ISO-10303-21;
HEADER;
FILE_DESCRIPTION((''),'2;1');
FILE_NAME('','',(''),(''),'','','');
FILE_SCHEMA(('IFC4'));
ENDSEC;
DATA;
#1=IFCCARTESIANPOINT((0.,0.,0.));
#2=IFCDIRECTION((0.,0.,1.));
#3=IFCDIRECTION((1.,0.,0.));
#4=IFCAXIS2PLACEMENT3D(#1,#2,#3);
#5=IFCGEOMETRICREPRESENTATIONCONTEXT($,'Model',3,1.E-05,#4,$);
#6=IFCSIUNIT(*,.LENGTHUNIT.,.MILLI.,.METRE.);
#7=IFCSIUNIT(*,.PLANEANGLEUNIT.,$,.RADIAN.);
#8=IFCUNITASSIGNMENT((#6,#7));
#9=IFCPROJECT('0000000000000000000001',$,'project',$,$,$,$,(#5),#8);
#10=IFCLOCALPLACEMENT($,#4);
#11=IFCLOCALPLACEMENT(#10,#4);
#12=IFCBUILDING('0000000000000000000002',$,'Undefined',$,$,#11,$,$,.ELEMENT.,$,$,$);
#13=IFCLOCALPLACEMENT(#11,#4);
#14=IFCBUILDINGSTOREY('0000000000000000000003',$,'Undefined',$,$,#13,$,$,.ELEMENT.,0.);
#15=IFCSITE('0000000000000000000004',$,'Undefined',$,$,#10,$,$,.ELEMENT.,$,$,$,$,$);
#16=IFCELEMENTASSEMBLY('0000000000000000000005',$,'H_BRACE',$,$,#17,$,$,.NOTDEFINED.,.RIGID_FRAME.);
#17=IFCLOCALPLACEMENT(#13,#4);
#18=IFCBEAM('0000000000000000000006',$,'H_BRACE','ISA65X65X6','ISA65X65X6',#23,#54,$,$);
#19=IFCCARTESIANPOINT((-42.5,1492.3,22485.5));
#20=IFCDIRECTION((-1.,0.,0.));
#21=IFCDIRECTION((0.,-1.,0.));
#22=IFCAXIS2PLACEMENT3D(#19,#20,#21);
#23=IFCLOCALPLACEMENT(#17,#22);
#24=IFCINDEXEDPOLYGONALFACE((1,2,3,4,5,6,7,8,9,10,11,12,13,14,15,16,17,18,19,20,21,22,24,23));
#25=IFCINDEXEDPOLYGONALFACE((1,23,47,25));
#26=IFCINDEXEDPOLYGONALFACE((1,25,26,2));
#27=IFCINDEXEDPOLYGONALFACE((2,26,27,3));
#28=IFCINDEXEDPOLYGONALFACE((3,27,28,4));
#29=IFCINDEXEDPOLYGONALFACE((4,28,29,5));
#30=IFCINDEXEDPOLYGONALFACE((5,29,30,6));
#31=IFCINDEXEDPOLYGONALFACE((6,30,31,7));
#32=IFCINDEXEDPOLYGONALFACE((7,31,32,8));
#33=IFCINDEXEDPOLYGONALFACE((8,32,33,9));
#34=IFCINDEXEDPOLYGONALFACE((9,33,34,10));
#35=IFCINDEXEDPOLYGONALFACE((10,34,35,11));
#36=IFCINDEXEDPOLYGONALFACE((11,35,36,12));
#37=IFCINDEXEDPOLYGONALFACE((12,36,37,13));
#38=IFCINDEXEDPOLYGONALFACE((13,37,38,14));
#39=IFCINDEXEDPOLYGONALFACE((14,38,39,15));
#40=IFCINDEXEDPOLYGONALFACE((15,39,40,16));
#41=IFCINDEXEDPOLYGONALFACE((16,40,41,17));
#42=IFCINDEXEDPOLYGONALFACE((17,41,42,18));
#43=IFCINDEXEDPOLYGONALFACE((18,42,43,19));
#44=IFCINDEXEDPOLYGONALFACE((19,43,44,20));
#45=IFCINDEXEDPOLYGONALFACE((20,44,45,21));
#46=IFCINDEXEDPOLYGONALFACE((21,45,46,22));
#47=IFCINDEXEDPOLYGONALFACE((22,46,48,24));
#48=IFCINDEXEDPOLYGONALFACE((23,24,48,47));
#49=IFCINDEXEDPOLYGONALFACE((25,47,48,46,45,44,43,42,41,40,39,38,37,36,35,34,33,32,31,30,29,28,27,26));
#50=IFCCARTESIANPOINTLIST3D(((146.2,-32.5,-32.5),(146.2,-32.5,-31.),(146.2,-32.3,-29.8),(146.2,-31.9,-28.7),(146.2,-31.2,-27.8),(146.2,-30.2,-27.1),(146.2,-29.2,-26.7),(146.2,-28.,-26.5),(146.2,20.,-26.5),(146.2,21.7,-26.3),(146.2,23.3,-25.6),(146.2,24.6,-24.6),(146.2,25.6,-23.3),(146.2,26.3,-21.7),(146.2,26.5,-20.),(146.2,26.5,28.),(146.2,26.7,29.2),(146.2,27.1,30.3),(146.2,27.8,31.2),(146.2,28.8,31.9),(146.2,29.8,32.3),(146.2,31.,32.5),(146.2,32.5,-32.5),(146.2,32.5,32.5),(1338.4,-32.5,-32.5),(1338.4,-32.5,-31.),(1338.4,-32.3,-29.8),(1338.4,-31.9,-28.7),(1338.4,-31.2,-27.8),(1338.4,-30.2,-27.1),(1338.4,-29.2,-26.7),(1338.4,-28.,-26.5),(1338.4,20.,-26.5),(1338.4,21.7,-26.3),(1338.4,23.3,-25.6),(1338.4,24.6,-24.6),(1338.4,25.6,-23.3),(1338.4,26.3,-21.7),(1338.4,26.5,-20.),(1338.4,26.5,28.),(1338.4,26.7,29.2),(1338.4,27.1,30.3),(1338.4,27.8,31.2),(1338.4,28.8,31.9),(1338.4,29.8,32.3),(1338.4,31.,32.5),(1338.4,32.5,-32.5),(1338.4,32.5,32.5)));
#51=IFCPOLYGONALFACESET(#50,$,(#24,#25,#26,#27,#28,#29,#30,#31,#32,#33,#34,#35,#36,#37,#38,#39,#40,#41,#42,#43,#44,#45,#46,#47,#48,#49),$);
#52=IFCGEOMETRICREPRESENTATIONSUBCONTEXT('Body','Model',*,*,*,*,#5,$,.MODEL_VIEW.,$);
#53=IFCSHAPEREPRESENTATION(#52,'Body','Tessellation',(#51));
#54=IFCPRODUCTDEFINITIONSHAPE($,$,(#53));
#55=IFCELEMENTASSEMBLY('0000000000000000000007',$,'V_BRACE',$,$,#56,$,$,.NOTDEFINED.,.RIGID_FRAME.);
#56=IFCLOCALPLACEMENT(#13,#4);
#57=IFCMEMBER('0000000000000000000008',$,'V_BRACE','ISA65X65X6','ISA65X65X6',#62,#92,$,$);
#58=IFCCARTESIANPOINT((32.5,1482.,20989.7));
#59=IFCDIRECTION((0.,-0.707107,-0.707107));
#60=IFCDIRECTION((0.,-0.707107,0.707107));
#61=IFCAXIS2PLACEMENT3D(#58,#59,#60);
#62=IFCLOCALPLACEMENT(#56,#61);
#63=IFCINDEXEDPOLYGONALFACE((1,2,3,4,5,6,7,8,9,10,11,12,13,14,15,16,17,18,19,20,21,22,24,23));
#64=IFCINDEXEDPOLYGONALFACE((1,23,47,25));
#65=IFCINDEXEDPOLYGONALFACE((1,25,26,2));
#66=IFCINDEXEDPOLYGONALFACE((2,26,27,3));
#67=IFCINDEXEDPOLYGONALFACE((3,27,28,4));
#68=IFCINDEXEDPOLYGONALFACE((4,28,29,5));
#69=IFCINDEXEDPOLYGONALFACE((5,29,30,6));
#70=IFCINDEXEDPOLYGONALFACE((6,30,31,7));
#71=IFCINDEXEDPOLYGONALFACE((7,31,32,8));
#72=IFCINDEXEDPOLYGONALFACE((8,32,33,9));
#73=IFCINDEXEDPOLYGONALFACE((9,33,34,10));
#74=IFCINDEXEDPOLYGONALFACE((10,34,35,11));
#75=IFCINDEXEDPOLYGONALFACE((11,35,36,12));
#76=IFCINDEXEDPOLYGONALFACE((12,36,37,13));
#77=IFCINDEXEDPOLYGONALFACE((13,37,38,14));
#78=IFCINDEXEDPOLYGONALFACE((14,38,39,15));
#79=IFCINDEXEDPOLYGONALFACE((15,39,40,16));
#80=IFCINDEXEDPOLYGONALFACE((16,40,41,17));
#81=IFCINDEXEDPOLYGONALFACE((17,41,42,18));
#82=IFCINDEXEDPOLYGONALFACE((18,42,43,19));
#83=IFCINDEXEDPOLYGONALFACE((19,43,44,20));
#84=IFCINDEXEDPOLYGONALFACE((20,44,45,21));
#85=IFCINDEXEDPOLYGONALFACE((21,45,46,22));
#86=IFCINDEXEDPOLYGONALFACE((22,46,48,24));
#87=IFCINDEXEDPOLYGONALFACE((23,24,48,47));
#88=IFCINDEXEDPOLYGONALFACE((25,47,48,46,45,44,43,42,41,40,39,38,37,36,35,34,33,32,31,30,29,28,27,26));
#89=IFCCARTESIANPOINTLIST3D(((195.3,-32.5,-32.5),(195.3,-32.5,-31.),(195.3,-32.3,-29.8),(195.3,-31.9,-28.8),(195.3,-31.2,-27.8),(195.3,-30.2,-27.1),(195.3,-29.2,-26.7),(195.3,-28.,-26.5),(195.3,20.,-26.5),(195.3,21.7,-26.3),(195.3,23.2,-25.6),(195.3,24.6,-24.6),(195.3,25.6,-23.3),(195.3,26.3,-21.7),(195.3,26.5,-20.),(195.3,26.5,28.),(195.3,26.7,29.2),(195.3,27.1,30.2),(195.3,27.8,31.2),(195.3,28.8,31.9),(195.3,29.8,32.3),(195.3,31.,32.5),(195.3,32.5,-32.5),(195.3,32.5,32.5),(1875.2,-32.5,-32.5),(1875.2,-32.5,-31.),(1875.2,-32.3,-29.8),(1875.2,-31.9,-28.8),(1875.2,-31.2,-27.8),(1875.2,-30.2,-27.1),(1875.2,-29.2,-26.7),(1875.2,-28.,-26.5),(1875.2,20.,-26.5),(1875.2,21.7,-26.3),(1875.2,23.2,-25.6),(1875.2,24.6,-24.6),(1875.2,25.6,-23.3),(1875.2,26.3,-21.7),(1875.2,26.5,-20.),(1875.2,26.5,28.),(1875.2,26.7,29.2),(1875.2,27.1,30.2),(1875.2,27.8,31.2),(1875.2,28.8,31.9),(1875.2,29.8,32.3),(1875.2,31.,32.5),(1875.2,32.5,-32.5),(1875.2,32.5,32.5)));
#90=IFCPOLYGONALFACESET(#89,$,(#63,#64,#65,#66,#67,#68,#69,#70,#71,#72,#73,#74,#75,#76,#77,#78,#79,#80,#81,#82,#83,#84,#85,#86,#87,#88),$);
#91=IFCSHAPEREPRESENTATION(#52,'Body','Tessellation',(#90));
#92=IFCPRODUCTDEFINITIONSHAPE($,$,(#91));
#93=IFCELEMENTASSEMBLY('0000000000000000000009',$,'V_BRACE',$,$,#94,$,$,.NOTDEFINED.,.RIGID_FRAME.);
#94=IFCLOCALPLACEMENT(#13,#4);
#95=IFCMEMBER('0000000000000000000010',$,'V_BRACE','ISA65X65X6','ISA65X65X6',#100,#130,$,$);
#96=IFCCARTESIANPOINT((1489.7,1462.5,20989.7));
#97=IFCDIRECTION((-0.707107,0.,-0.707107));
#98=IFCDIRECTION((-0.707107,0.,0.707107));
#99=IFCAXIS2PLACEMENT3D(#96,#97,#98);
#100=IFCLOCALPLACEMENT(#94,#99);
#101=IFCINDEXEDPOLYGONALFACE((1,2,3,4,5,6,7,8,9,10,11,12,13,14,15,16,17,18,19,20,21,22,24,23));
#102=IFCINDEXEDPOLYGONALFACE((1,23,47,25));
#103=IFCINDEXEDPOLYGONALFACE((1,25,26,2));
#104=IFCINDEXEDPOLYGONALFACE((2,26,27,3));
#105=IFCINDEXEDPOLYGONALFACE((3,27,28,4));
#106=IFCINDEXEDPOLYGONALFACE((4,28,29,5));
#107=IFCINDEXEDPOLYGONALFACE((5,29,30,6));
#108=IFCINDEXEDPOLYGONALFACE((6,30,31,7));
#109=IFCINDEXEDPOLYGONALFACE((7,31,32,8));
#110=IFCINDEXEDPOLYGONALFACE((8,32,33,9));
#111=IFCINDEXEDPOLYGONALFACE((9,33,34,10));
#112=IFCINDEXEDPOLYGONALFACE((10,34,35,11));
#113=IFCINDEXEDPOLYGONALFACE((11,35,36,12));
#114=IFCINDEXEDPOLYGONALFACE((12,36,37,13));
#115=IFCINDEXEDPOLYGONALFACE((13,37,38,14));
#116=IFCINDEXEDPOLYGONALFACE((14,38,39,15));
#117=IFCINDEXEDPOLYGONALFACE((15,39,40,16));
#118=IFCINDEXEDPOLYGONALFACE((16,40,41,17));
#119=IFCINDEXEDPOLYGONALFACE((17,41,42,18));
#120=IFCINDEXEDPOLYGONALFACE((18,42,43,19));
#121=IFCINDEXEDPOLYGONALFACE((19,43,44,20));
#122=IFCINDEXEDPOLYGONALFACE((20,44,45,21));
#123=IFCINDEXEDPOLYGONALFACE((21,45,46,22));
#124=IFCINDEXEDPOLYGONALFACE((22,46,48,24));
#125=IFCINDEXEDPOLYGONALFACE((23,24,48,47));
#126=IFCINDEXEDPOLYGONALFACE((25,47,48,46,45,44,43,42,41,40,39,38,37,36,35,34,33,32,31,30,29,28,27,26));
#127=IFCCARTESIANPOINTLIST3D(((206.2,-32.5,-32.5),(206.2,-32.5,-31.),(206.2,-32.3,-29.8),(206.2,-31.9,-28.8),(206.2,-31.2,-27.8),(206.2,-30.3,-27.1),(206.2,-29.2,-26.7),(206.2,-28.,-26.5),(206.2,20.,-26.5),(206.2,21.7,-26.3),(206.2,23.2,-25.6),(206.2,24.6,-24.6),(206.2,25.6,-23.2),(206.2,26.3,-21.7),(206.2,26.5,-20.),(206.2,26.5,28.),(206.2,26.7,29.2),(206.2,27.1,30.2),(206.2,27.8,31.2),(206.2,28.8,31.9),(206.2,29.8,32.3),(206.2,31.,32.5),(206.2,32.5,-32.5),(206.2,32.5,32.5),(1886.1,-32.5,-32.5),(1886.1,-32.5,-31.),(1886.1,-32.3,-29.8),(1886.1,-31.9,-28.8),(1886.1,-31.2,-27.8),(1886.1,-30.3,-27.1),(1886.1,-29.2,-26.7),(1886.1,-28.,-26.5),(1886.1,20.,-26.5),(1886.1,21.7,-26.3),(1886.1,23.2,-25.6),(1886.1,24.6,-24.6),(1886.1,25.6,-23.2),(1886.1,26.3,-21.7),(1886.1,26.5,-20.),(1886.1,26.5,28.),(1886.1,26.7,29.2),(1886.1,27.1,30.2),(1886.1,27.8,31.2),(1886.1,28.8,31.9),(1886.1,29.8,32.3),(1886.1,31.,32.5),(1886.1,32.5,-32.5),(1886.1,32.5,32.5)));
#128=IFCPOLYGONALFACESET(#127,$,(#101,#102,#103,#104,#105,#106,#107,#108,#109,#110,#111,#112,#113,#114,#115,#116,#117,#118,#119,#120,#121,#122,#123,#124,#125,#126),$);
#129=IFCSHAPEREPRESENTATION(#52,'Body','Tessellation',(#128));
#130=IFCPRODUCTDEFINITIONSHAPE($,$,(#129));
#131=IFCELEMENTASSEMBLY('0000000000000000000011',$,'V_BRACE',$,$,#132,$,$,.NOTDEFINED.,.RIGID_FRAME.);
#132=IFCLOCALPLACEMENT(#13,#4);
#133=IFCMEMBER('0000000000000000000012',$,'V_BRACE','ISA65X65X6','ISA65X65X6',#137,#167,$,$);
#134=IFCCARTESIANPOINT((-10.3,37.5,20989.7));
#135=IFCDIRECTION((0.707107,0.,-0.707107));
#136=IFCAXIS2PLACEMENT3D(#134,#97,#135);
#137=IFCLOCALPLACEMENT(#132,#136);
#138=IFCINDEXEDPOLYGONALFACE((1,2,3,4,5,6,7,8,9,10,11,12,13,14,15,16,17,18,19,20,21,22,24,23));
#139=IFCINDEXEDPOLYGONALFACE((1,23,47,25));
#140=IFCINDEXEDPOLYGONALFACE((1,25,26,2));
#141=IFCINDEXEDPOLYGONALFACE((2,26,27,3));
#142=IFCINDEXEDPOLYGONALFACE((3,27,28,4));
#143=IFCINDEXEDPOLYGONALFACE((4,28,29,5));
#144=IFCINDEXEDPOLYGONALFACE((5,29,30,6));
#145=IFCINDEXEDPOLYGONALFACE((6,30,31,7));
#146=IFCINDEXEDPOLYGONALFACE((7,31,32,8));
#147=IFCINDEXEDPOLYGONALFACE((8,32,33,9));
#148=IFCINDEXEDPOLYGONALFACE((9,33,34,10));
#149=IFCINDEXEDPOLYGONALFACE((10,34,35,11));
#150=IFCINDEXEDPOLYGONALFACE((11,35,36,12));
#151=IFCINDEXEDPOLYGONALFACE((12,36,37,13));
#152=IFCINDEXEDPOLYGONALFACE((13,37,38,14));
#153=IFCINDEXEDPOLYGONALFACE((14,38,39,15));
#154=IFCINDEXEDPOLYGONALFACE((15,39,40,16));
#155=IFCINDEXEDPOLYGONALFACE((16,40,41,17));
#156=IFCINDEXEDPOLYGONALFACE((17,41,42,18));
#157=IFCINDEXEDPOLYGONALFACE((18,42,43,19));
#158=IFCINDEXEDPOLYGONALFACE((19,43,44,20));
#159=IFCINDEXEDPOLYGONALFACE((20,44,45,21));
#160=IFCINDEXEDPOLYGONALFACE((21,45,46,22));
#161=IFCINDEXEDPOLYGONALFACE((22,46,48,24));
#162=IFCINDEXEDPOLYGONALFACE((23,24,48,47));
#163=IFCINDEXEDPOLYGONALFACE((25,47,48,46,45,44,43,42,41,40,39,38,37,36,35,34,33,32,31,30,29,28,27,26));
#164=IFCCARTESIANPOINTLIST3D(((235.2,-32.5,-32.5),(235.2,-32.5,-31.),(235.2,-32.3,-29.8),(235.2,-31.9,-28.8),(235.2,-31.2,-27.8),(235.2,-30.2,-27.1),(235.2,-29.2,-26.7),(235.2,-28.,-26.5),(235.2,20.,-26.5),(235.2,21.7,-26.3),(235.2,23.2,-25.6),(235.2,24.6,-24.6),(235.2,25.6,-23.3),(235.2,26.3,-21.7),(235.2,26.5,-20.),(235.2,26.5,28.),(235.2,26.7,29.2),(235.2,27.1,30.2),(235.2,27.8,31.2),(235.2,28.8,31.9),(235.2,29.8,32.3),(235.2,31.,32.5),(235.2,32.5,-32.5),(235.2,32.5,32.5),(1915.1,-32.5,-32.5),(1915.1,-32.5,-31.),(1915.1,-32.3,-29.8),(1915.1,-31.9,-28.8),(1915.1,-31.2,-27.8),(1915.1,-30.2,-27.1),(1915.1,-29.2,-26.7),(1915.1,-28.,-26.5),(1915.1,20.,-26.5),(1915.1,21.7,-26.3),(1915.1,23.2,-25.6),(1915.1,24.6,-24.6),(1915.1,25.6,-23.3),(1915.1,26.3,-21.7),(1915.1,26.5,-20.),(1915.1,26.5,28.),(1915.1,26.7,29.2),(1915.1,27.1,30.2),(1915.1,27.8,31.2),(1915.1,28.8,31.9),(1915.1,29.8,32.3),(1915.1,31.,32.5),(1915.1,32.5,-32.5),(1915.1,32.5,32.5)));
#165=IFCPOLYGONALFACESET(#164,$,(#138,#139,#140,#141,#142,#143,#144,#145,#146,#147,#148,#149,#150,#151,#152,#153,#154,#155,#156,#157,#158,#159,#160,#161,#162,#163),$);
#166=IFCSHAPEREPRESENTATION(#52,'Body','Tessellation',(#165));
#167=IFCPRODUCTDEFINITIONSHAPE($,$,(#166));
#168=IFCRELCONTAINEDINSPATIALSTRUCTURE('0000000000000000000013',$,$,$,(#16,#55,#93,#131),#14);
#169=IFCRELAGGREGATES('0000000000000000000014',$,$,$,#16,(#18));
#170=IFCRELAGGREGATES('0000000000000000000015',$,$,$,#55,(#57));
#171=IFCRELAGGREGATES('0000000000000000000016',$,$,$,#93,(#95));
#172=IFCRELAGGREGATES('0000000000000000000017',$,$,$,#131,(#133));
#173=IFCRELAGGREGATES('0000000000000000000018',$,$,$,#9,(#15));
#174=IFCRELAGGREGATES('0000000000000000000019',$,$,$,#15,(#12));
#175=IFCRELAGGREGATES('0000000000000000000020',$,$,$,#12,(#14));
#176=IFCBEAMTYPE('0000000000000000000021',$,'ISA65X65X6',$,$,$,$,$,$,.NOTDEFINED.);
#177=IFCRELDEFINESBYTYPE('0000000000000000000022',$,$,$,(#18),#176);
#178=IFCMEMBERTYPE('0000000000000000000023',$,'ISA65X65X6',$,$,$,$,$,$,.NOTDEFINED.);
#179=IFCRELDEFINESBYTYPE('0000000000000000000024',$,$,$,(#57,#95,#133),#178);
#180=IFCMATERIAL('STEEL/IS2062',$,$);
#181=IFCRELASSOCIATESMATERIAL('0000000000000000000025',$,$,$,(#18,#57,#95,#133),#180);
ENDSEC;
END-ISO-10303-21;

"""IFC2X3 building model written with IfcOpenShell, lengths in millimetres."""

from ifc_helpers import new_model, si_unit, frame, origin_with_axes, origin_2d_with_axis, place, context, subcontext, project, spatial, l_section, extrude, clip, halfspace, material, type_object, element, aggregate, save


model = new_model("IFC2X3")

# Units and contexts
model_context = context("Model", 3, precision=1e-05, world=origin_with_axes())
body_context = subcontext(model_context, "Body", "Model", "MODEL_VIEW")
ifc_project = project(units=[si_unit("LENGTHUNIT", "METRE", prefix="MILLI"), si_unit("PLANEANGLEUNIT", "RADIAN")], contexts=[model_context])

# Site, building, storey
site_placement = place(None, origin_with_axes())
site = spatial("IfcSite", under=ifc_project, at=site_placement, Name="Undefined", CompositionType="ELEMENT")
building_placement = place(site_placement, origin_with_axes())
building = spatial("IfcBuilding", under=site, at=building_placement, Name="Undefined", CompositionType="ELEMENT")
storey_placement = place(building_placement, origin_with_axes())
storey = spatial("IfcBuildingStorey", under=building, at=storey_placement, Name="Undefined", CompositionType="ELEMENT", Elevation=0.0)

# Shared definitions
ifc_material = material(Name="STEEL/IS2062")

# Element assembly, beam
assembly_1_placement = place(storey_placement, origin_with_axes())
assembly_1 = element("IfcElementAssembly", 1, at=assembly_1_placement, inside=storey, Name="H_BRACE", AssemblyPlace="NOTDEFINED", PredefinedType="RIGID_FRAME")
beam_type_1 = type_object("IfcBeamType", Name="ISA65X65X6", PredefinedType="NOTDEFINED")
beam_1_placement = place(assembly_1_placement, frame((-42.5, 1492.3, 22485.5), z_axis=(-1.0, 0.0, 0.0), x_axis=(0.0, -1.0, 0.0)))
beam_1 = element("IfcBeam", 2, at=beam_1_placement, type_object=beam_type_1, material=ifc_material, Name="H_BRACE", Description="ISA65X65X6", ObjectType="ISA65X65X6", context=body_context, shape_type="Clipping", body=[
    clip(clip(extrude(l_section(Depth=65.0, Width=65.0, Thickness=6.0, FilletRadius=6.5, EdgeRadius=4.5, at=origin_2d_with_axis()), frame((1500.0, 0.0, 0.0), z_axis=(-1.0, 0.0, 0.0), x_axis=(0.0, -1.0, 0.0)), (0.0, 0.0, 1.0), 1500.0), halfspace(frame((1338.4, 0.0, -42.5), z_axis=(-1.0, 0.0, 0.0), x_axis=(0.0, -1.0, 0.0)), True)), halfspace(frame((146.2, 0.0, -32.5), z_axis=(1.0, 0.0, 0.0), x_axis=(0.0, 1.0, 0.0)), True)),
])
aggregate(assembly_1, [beam_1])

# Element assemblies, members
assembly_2_placement = place(storey_placement, origin_with_axes())
assembly_2 = element("IfcElementAssembly", 3, at=assembly_2_placement, inside=storey, Name="V_BRACE", AssemblyPlace="NOTDEFINED", PredefinedType="RIGID_FRAME")
member_type = type_object("IfcMemberType", Name="ISA65X65X6", PredefinedType="NOTDEFINED")
member_1_placement = place(assembly_2_placement, frame((32.5, 1482.0, 20989.7), z_axis=(0.0, -0.707107, -0.707107), x_axis=(0.0, -0.707107, 0.707107)))
member_1 = element("IfcMember", 4, at=member_1_placement, type_object=member_type, material=ifc_material, Name="V_BRACE", Description="ISA65X65X6", ObjectType="ISA65X65X6", context=body_context, shape_type="Clipping", body=[
    clip(clip(extrude(l_section(Depth=65.0, Width=65.0, Thickness=6.0, FilletRadius=6.5, EdgeRadius=4.5, at=origin_2d_with_axis()), frame((2121.3, 0.0, 0.0), z_axis=(-1.0, 0.0, 0.0), x_axis=(0.0, -1.0, 0.0)), (0.0, 0.0, 1.0), 2121.3), halfspace(frame((1875.2, 42.5, 0.0), z_axis=(-1.0, 0.0, 0.0), x_axis=(0.0, 0.0, 1.0)), True)), halfspace(frame((195.3, 42.5, 0.0), z_axis=(1.0, 0.0, 0.0), x_axis=(0.0, 0.0, -1.0)), True)),
])
aggregate(assembly_2, [member_1])
assembly_3_placement = place(storey_placement, origin_with_axes())
assembly_3 = element("IfcElementAssembly", 5, at=assembly_3_placement, inside=storey, Name="V_BRACE", AssemblyPlace="NOTDEFINED", PredefinedType="RIGID_FRAME")
member_2_placement = place(assembly_3_placement, frame((1489.7, 1462.5, 20989.7), z_axis=(-0.707107, 0.0, -0.707107), x_axis=(-0.707107, 0.0, 0.707107)))
member_2 = element("IfcMember", 6, at=member_2_placement, type_object=member_type, material=ifc_material, Name="V_BRACE", Description="ISA65X65X6", ObjectType="ISA65X65X6", context=body_context, shape_type="Clipping", body=[
    clip(clip(extrude(l_section(Depth=65.0, Width=65.0, Thickness=6.0, FilletRadius=6.5, EdgeRadius=4.5, at=origin_2d_with_axis()), frame((2121.3, 0.0, 0.0), z_axis=(-1.0, 0.0, 0.0), x_axis=(0.0, -1.0, 0.0)), (0.0, 0.0, 1.0), 2121.3), halfspace(frame((1886.1, 32.5, 0.0), z_axis=(-1.0, 0.0, 0.0), x_axis=(0.0, 0.0, -1.0)), True)), halfspace(frame((206.2, 32.5, 0.0), z_axis=(1.0, 0.0, 0.0), x_axis=(0.0, 0.0, 1.0)), True)),
])
aggregate(assembly_3, [member_2])
assembly_4_placement = place(storey_placement, origin_with_axes())
assembly_4 = element("IfcElementAssembly", 7, at=assembly_4_placement, inside=storey, Name="V_BRACE", AssemblyPlace="NOTDEFINED", PredefinedType="RIGID_FRAME")
member_3_placement = place(assembly_4_placement, frame((-10.3, 37.5, 20989.7), z_axis=(-0.707107, 0.0, -0.707107), x_axis=(0.707107, 0.0, -0.707107)))
member_3 = element("IfcMember", 8, at=member_3_placement, type_object=member_type, material=ifc_material, Name="V_BRACE", Description="ISA65X65X6", ObjectType="ISA65X65X6", context=body_context, shape_type="Clipping", body=[
    clip(clip(extrude(l_section(Depth=65.0, Width=65.0, Thickness=6.0, FilletRadius=6.5, EdgeRadius=4.5, at=origin_2d_with_axis()), frame((2121.3, 0.0, 0.0), z_axis=(-1.0, 0.0, 0.0), x_axis=(0.0, -1.0, 0.0)), (0.0, 0.0, 1.0), 2121.3), halfspace(frame((1915.1, 42.5, 0.0), z_axis=(-1.0, 0.0, 0.0), x_axis=(0.0, 0.0, 1.0)), True)), halfspace(frame((235.2, 42.5, 0.0), z_axis=(1.0, 0.0, 0.0), x_axis=(0.0, 0.0, -1.0)), True)),
])
aggregate(assembly_4, [member_3])

save(model, "model.ifc")
